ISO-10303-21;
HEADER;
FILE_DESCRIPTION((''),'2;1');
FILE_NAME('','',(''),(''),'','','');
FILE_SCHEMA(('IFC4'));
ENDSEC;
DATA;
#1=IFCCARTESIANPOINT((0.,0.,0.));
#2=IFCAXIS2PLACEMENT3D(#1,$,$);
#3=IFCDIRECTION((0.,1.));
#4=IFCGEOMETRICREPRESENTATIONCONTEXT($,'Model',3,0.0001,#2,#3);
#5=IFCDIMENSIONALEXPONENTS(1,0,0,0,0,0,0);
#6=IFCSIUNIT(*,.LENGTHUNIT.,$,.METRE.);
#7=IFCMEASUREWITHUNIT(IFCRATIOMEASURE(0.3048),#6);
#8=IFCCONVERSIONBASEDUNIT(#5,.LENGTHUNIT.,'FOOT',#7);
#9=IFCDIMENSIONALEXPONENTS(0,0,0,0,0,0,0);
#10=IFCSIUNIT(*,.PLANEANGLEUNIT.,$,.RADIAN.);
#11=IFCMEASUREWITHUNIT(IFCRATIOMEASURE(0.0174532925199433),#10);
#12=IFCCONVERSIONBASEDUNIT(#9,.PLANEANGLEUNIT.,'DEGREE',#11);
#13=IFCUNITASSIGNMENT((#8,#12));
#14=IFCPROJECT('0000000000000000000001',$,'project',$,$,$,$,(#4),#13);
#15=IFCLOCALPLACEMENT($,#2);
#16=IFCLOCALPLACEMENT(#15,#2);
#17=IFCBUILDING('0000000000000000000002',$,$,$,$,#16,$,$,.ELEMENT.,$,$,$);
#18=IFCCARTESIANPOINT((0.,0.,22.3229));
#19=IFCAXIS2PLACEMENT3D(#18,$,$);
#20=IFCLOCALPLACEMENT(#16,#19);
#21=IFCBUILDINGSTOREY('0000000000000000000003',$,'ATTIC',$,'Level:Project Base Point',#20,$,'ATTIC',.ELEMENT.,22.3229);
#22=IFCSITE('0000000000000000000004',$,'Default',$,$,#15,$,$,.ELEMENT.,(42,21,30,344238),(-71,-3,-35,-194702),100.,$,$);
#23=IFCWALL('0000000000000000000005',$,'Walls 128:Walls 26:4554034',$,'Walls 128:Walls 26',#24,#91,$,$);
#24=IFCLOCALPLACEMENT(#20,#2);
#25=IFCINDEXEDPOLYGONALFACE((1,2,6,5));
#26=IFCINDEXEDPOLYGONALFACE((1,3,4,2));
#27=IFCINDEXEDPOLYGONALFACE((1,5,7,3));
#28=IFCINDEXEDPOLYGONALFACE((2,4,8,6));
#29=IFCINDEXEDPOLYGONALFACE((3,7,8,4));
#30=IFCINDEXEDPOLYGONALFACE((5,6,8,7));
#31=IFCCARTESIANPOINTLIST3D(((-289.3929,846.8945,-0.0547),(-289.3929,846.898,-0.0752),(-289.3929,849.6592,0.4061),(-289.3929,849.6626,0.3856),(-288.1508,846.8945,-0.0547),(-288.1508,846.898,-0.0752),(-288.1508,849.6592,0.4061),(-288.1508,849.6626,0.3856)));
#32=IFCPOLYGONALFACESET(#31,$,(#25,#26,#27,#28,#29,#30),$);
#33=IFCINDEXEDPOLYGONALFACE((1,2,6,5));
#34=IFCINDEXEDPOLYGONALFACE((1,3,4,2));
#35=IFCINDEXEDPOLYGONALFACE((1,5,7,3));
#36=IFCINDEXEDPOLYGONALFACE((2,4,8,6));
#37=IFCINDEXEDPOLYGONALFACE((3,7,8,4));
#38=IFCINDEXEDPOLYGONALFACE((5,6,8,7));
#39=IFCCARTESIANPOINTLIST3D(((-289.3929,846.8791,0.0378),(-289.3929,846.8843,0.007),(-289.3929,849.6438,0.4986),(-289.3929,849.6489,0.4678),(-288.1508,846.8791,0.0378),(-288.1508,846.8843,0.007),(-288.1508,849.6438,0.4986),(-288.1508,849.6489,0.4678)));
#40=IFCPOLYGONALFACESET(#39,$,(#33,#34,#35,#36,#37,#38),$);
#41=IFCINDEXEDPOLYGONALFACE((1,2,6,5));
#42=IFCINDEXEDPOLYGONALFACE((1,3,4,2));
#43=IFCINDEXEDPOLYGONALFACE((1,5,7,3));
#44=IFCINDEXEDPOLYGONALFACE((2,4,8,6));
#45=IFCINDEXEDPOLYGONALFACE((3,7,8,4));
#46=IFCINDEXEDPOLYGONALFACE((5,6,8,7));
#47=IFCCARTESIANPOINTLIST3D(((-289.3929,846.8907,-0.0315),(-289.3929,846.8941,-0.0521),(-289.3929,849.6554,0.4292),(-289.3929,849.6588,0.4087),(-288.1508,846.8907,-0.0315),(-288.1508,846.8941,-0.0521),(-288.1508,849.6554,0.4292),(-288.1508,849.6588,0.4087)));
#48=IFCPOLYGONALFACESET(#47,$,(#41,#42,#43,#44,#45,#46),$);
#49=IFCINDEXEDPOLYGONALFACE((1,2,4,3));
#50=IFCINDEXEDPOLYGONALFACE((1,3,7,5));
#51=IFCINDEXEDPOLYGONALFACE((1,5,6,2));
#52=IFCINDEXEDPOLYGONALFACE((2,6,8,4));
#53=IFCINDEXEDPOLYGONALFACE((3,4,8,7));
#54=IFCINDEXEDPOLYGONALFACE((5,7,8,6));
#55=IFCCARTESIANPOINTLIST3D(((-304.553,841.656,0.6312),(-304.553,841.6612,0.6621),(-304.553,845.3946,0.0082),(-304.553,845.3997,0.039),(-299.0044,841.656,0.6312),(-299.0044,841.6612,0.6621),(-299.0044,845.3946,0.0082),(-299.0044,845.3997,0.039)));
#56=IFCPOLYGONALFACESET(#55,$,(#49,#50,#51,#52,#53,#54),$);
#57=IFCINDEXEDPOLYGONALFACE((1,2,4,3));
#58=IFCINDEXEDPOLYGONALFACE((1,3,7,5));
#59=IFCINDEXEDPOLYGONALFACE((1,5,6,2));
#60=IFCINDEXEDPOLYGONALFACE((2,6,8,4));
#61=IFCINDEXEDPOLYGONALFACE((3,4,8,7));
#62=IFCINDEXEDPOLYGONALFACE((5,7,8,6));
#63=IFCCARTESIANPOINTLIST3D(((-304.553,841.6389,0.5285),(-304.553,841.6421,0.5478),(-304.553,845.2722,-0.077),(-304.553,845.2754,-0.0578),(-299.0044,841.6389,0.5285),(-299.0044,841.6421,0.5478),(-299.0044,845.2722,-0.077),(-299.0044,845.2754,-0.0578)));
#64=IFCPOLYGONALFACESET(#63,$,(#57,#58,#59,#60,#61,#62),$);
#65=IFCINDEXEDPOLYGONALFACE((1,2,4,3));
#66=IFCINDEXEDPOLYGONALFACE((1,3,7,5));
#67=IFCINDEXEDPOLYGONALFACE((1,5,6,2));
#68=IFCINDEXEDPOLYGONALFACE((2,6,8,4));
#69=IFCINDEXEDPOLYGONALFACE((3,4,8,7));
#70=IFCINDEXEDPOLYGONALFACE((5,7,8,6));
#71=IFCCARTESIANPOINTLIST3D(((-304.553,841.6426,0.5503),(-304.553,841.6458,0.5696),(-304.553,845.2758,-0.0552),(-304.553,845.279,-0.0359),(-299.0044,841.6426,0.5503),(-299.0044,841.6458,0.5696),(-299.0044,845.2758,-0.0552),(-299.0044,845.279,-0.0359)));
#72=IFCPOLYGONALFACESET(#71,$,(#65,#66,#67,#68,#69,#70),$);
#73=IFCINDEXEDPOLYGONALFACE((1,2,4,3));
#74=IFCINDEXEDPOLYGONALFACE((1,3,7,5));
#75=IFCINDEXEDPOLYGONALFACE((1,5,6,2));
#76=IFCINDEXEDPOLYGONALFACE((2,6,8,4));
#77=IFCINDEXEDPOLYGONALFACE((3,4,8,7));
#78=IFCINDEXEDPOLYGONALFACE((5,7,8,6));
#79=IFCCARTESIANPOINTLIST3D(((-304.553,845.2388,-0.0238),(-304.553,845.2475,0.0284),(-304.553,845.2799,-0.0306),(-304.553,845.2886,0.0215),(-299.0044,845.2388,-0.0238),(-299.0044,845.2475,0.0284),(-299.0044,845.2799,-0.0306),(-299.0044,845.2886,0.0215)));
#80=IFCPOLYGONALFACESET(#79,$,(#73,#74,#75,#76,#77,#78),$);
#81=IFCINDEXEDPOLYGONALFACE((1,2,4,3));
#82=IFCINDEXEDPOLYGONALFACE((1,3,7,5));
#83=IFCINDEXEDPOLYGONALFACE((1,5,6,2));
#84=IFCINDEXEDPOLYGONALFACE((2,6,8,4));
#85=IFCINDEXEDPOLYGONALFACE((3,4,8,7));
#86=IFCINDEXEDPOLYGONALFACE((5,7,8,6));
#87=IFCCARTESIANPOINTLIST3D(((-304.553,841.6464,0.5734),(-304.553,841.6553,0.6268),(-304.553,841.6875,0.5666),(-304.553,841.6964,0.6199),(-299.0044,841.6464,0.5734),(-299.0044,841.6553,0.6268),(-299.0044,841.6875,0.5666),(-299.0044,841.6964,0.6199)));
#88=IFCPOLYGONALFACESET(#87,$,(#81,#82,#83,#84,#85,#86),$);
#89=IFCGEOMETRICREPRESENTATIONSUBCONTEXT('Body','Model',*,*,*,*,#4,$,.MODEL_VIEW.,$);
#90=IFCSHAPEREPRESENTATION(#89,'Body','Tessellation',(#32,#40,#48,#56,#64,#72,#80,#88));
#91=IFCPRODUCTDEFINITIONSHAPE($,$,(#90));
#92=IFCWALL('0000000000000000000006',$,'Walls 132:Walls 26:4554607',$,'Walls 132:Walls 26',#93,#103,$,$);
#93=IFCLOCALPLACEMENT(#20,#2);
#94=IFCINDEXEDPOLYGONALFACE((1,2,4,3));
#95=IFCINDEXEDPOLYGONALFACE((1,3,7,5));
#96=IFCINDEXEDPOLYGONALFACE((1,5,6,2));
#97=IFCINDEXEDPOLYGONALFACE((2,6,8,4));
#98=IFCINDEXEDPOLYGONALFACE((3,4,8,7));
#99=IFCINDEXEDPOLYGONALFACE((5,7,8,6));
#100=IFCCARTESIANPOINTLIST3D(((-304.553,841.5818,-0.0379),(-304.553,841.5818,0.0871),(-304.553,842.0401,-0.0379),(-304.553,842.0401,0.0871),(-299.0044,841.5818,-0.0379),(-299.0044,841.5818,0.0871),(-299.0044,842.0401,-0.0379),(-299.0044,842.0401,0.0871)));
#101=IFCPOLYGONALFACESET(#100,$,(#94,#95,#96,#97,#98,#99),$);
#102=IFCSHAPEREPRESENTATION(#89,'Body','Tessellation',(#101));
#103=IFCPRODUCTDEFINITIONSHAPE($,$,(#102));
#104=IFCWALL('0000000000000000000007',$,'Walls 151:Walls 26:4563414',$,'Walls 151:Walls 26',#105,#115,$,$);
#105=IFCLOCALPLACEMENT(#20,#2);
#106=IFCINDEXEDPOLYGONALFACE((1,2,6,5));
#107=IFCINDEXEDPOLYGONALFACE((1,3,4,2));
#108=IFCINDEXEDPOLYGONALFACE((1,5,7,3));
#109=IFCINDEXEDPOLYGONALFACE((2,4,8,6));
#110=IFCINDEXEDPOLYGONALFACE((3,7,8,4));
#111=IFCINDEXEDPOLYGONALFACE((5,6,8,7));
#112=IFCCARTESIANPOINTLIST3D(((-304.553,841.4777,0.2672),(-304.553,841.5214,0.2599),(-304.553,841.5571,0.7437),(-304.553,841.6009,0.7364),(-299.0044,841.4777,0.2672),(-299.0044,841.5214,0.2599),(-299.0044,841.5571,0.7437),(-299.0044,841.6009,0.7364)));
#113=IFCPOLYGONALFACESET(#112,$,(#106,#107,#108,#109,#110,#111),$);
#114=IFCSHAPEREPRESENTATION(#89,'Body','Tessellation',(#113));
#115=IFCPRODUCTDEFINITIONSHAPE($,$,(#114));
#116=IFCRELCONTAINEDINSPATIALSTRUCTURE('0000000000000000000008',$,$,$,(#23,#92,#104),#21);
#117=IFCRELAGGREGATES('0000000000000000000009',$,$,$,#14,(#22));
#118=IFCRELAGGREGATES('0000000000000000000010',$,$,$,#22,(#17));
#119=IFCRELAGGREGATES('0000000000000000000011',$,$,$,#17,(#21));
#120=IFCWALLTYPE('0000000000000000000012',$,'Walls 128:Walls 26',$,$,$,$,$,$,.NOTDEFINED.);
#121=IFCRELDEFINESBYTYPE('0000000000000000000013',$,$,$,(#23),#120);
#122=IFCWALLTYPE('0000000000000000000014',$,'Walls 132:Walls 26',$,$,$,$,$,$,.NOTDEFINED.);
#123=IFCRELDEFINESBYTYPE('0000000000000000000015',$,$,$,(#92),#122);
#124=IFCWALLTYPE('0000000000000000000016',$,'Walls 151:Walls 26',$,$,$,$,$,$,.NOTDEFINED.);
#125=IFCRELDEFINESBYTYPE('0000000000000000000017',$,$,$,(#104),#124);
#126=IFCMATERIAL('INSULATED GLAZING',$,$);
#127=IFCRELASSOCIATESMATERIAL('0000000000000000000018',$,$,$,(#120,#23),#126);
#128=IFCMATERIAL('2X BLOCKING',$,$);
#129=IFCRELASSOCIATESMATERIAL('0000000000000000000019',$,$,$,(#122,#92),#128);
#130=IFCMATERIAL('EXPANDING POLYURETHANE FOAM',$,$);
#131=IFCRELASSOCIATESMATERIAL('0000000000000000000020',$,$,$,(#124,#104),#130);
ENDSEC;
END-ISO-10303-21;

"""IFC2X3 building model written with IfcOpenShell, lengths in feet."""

from ifc_helpers import new_model, entity, si_unit, converted_unit, direction, frame, frame_2d, origin, origin_2d_with_axis, place, context, subcontext, project, spatial, rectangle, extrude, material, type_object, element, save


model = new_model("IFC2X3")

# Units and contexts
model_context = context("Model", 3, precision=0.0001, world=origin(), true_north=direction((0.0, 1.0)))
body_context = subcontext(model_context, "Body", "Model", "MODEL_VIEW")
ifc_project = project(units=[converted_unit("LENGTHUNIT", "FOOT", entity("IfcRatioMeasure", 0.3048), si_unit("LENGTHUNIT", "METRE"), dimensions=[1, 0, 0, 0, 0, 0, 0]), converted_unit("PLANEANGLEUNIT", "DEGREE", entity("IfcRatioMeasure", 0.0174532925199433), si_unit("PLANEANGLEUNIT", "RADIAN"), dimensions=[0, 0, 0, 0, 0, 0, 0])], contexts=[model_context])

# Site, building, storey
site_placement = place(None, origin())
site = spatial("IfcSite", under=ifc_project, at=site_placement, Name="Default", CompositionType="ELEMENT", RefLatitude=(42, 21, 30, 344238), RefLongitude=(-71, -3, -35, -194702), RefElevation=100.0)
building_placement = place(site_placement, origin())
building = spatial("IfcBuilding", under=site, at=building_placement, CompositionType="ELEMENT")
storey_placement = place(building_placement, frame((0.0, 0.0, 22.3229)))
storey = spatial("IfcBuildingStorey", under=building, at=storey_placement, Name="ATTIC", ObjectType="Level:Project Base Point", LongName="ATTIC", CompositionType="ELEMENT", Elevation=22.3229)

# Walls
ifc_material_1 = material(Name="INSULATED GLAZING")
wall_type_1 = type_object("IfcWallType", Name="Walls 128:Walls 26", PredefinedType="NOTDEFINED", material=ifc_material_1)
wall_1_placement = place(storey_placement, frame((-304.553, 841.6389, -0.077)))
element("IfcWall", 1, at=wall_1_placement, inside=storey, type_object=wall_type_1, material=ifc_material_1, Name="Walls 128:Walls 26:4554034", ObjectType="Walls 128:Walls 26", context=body_context, shape_type="SweptSolid", body=[
    extrude(rectangle(XDim=2.8028, YDim=1.2421, at=origin_2d_with_axis()), frame((15.7811, 6.6414, 0.2322), z_axis=(0.0, -0.164399, 0.986394), x_axis=(0.0, -0.986394, -0.164399)), (0.0, 0.0, 1.0), 0.0208),
    extrude(rectangle(XDim=2.8028, YDim=1.2421, at=frame_2d((0.0, 0.0), x_axis=(1.0, 0.0))), frame((15.7811, 6.6277, 0.3144), z_axis=(0.0, -0.164399, 0.986394), x_axis=(0.0, -0.986394, -0.164399)), (0.0, 0.0, 1.0), 0.0312),
    extrude(rectangle(XDim=2.8028, YDim=1.2421, at=frame_2d((0.0, 0.0), x_axis=(1.0, 0.0))), frame((15.7811, 6.6375, 0.2553), z_axis=(0.0, -0.164399, 0.986394), x_axis=(0.0, -0.986394, -0.164399)), (0.0, 0.0, 1.0), 0.0208),
    extrude(rectangle(XDim=3.7901, YDim=5.5486, at=frame_2d((0.0, 0.0), x_axis=(0.0, 1.0))), frame((2.7743, 1.8864, 0.3967), z_axis=(0.0, 0.164399, 0.986394), x_axis=(-1.0, 0.0, 0.0)), (0.0, 0.0, 1.0), 0.0313),
    extrude(rectangle(XDim=3.6834, YDim=5.5486, at=frame_2d((0.0, 0.0), x_axis=(0.0, 1.0))), frame((2.7743, 1.8166, 0.3028), z_axis=(0.0, 0.164399, 0.986394), x_axis=(-1.0, 0.0, 0.0)), (0.0, 0.0, 1.0), 0.0195),
    extrude(rectangle(XDim=3.6834, YDim=5.5486, at=frame_2d((0.0, 0.0), x_axis=(0.0, 1.0))), frame((2.7743, 1.8203, 0.3246), z_axis=(0.0, 0.164399, 0.986394), x_axis=(-1.0, 0.0, 0.0)), (0.0, 0.0, 1.0), 0.0195),
    extrude(rectangle(XDim=0.0417, YDim=5.5486, at=frame_2d((0.0, 0.0), x_axis=(0.0, 1.0))), frame((2.7743, 3.6204, 0.0498), z_axis=(0.0, 0.164399, 0.986394), x_axis=(-1.0, 0.0, 0.0)), (0.0, 0.0, 1.0), 0.0529),
    extrude(rectangle(XDim=0.0417, YDim=5.5486, at=frame_2d((0.0, 0.0), x_axis=(0.0, 1.0))), frame((2.7743, 0.028, 0.647), z_axis=(0.0, 0.164399, 0.986394), x_axis=(-1.0, 0.0, 0.0)), (0.0, 0.0, 1.0), 0.0541),
])
ifc_material_2 = material(Name="2X BLOCKING")
wall_type_2 = type_object("IfcWallType", Name="Walls 132:Walls 26", PredefinedType="NOTDEFINED", material=ifc_material_2)
wall_2_placement = place(storey_placement, frame((-304.553, 841.5818, -0.0379)))
element("IfcWall", 2, at=wall_2_placement, inside=storey, type_object=wall_type_2, material=ifc_material_2, Name="Walls 132:Walls 26:4554607", ObjectType="Walls 132:Walls 26", context=body_context, shape_type="SweptSolid", body=[
    extrude(rectangle(XDim=5.5486, YDim=0.4583, at=origin_2d_with_axis()), frame((2.7743, 0.2292, 0.0), z_axis=(0.0, 0.0, 1.0), x_axis=(-1.0, 0.0, 0.0)), (0.0, 0.0, 1.0), 0.125),
])
ifc_material_3 = material(Name="EXPANDING POLYURETHANE FOAM")
wall_type_3 = type_object("IfcWallType", Name="Walls 151:Walls 26", PredefinedType="NOTDEFINED", material=ifc_material_3)
wall_3_placement = place(storey_placement, frame((-304.553, 841.4777, 0.2599)))
element("IfcWall", 3, at=wall_3_placement, inside=storey, type_object=wall_type_3, material=ifc_material_3, Name="Walls 151:Walls 26:4563414", ObjectType="Walls 151:Walls 26", context=body_context, shape_type="SweptSolid", body=[
    extrude(rectangle(XDim=0.0443, YDim=5.5486, at=frame_2d((0.0, 0.0), x_axis=(0.0, 1.0))), frame((2.7743, 0.0219, 0.0036), z_axis=(0.0, 0.164399, 0.986394), x_axis=(-1.0, 0.0, 0.0)), (0.0, 0.0, 1.0), 0.4831),
])

save(model, "model.ifc")
